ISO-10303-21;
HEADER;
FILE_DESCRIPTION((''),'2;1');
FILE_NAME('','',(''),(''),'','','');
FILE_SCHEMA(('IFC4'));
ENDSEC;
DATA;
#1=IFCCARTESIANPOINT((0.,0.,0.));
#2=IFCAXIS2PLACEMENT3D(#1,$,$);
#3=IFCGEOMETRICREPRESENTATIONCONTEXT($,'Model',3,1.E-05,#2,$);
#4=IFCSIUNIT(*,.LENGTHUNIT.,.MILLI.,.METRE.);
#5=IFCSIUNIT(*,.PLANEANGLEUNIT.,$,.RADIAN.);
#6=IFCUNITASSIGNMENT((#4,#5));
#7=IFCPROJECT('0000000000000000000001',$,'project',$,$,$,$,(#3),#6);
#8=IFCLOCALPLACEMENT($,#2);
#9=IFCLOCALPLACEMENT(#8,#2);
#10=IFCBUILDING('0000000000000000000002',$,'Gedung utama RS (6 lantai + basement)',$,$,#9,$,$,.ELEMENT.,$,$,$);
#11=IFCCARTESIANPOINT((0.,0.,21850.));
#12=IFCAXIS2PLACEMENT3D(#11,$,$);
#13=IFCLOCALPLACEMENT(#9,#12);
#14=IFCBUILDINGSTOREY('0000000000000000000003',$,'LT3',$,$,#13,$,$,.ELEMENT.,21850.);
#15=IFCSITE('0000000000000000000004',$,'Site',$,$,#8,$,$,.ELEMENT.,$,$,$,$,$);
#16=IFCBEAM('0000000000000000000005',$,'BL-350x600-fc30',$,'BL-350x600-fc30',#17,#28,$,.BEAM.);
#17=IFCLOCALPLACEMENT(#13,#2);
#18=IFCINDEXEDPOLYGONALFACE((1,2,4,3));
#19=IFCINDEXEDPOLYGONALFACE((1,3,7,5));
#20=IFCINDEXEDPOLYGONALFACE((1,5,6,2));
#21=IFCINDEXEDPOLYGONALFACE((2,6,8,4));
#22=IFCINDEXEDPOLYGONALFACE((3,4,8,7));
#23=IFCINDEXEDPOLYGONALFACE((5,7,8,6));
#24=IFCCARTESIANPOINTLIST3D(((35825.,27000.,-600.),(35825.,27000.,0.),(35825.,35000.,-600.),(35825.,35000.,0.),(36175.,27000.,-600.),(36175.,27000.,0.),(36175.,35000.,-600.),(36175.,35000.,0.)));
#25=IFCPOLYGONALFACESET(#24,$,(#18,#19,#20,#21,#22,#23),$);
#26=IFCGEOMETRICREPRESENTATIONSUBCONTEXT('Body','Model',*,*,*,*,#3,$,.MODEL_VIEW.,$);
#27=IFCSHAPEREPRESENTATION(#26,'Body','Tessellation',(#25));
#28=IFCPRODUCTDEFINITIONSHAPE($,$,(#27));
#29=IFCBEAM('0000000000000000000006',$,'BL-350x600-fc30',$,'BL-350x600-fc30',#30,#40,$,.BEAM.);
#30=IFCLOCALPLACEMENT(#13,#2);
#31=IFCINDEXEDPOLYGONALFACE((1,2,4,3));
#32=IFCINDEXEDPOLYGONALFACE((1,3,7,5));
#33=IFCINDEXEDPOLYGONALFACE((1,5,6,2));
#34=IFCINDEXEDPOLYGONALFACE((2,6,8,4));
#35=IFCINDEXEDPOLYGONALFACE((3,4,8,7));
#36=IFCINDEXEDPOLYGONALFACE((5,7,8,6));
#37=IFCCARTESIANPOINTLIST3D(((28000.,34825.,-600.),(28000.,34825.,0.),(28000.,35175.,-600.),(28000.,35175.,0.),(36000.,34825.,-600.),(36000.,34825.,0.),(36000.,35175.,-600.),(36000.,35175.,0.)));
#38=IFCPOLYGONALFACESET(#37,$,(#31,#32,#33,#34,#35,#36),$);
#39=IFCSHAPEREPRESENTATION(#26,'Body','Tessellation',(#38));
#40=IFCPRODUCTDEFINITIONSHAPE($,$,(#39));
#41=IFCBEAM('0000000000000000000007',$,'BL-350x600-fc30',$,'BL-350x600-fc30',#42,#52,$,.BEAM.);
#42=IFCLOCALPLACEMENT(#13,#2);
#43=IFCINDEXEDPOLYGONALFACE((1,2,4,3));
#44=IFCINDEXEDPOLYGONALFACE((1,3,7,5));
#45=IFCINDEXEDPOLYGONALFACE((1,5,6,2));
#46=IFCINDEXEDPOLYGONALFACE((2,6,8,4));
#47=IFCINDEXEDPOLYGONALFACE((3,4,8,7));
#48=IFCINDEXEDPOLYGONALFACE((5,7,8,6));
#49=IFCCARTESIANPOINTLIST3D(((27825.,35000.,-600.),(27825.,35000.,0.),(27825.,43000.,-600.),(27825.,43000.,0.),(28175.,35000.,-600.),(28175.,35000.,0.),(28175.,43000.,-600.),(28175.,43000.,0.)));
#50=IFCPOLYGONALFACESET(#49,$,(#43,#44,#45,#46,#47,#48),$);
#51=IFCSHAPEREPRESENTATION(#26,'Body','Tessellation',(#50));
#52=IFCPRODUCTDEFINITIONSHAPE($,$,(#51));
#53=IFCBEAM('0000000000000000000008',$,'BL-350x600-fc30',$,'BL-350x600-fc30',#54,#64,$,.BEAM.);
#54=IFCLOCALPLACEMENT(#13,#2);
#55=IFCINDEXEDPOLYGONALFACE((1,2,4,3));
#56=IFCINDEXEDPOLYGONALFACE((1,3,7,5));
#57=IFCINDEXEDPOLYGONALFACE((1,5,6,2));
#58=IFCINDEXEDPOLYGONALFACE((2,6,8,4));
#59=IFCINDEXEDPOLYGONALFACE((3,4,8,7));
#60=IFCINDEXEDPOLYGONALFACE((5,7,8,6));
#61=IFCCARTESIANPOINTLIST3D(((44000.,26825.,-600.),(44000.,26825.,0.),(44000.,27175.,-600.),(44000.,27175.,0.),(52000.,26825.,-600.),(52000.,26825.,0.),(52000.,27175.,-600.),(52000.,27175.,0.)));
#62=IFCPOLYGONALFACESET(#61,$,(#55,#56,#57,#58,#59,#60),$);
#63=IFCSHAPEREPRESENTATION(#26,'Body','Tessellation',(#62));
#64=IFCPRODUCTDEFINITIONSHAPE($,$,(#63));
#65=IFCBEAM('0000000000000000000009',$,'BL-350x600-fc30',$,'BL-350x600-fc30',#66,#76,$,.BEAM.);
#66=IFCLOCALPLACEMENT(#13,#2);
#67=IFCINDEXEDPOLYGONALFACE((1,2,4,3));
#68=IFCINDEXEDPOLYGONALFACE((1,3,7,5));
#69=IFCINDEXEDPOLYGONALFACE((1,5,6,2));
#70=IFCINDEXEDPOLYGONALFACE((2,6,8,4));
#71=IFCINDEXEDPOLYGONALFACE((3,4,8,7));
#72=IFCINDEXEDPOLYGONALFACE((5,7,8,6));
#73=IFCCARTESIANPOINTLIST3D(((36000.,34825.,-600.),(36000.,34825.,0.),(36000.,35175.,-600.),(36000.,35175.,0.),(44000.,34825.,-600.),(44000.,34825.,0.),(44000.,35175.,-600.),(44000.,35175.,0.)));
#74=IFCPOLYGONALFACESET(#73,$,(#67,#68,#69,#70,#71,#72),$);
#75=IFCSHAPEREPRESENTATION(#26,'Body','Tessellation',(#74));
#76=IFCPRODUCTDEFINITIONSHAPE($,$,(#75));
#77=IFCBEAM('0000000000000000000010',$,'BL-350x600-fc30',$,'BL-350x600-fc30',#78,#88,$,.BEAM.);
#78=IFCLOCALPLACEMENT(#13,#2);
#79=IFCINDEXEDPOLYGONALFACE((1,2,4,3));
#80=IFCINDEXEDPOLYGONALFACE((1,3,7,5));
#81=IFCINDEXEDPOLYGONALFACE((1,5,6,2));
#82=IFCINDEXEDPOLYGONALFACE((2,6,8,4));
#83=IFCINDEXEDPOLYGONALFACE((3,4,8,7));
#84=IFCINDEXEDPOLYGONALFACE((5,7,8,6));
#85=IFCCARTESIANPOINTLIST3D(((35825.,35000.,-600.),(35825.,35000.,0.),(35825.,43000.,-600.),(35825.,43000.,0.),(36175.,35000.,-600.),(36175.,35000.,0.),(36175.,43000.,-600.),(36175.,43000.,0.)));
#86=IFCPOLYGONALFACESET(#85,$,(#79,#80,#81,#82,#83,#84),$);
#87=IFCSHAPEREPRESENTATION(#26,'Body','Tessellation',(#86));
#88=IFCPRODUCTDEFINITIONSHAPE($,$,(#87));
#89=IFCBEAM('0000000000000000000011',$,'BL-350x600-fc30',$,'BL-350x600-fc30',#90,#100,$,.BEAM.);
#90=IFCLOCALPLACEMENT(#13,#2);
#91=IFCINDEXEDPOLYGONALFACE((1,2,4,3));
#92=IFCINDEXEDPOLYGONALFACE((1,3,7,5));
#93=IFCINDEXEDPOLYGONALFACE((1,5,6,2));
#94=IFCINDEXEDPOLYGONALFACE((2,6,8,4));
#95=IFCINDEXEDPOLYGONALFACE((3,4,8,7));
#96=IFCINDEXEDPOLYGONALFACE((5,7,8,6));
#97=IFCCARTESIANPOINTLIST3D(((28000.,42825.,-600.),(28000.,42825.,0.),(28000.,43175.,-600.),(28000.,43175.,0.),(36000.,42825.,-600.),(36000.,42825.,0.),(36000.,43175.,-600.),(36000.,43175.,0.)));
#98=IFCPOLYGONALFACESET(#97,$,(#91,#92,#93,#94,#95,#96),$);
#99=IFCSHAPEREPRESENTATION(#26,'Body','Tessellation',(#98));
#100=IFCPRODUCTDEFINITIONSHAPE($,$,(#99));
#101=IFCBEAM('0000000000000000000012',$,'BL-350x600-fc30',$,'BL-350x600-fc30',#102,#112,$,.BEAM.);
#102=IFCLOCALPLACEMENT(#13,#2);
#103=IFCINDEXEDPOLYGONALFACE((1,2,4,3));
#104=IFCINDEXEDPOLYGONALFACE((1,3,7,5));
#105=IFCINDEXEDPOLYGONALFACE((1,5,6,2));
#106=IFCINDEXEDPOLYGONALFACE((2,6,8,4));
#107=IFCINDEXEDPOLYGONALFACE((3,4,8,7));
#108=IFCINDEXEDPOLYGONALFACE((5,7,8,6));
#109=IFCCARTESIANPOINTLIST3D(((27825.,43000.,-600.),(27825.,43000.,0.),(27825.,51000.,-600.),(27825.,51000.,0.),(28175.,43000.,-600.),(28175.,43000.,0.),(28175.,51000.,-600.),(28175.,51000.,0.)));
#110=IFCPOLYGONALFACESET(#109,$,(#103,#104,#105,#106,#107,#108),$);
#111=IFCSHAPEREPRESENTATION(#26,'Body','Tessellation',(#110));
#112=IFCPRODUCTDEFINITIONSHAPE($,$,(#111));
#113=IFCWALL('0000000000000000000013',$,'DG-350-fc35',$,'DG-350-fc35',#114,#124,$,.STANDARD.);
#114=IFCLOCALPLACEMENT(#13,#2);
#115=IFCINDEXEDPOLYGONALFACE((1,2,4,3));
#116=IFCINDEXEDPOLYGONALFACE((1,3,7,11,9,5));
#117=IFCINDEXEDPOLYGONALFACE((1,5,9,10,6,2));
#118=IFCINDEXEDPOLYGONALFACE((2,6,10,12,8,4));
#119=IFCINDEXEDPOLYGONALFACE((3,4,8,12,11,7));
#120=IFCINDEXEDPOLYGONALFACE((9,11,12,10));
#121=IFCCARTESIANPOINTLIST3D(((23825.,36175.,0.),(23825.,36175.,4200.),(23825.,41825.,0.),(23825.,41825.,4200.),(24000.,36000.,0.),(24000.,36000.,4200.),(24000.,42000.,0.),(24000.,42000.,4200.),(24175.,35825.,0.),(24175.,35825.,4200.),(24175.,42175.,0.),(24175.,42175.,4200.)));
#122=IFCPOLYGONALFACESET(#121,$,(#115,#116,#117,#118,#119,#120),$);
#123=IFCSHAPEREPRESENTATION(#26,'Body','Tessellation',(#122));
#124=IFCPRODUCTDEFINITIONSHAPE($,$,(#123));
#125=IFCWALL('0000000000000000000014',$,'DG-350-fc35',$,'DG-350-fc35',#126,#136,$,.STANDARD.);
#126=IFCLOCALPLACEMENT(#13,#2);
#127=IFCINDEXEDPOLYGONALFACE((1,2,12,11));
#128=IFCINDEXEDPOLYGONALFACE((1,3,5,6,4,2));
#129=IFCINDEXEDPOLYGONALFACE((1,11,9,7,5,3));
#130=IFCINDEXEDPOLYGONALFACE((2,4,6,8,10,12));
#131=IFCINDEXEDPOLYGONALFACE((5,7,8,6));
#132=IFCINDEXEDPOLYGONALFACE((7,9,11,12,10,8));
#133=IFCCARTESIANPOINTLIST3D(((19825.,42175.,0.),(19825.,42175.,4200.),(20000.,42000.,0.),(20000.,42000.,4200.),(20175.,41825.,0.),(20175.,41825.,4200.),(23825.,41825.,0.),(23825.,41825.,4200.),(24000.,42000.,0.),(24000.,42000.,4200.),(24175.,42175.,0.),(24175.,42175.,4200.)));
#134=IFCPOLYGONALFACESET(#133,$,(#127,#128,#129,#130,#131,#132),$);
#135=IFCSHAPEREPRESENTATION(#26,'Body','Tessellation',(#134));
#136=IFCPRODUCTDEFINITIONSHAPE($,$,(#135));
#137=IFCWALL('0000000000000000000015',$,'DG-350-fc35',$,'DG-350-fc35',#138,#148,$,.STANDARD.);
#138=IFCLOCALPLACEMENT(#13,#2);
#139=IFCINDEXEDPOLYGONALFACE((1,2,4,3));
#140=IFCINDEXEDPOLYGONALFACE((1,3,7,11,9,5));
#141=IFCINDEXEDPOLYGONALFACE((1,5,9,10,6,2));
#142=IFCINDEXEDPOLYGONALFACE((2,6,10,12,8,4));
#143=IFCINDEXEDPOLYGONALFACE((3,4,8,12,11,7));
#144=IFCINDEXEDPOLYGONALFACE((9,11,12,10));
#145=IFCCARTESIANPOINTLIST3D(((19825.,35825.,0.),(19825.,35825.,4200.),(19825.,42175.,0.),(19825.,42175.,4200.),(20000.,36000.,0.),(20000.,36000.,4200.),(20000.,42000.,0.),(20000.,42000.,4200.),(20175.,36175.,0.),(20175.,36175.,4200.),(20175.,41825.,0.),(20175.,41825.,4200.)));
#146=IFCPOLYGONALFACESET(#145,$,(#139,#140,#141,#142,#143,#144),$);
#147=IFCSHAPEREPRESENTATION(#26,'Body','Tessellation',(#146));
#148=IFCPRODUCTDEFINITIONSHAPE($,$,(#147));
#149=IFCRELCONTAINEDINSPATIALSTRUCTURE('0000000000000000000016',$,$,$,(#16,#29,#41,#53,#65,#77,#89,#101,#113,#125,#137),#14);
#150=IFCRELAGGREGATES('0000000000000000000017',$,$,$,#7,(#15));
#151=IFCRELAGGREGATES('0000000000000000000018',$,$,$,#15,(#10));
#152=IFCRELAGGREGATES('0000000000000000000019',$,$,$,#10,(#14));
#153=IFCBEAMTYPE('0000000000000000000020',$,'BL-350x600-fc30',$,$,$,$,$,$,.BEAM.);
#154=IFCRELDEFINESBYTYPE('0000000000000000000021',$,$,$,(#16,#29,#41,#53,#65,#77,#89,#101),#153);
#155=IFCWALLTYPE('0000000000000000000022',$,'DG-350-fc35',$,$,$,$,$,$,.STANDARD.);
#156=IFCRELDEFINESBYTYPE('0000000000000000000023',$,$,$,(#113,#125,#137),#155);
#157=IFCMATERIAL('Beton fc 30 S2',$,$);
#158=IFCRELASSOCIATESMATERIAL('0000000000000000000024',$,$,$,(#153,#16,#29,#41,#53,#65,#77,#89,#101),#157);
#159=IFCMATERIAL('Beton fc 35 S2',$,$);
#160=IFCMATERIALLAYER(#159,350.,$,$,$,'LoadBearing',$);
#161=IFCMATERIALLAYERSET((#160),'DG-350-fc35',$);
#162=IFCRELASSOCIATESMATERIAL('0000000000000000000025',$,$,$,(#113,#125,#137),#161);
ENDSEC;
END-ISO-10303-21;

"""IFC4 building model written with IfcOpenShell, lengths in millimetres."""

from ifc_helpers import new_model, si_unit, frame, origin, origin_2d, place, context, subcontext, project, spatial, polyline, rectangle, outline, extrude, material, layer, layer_set, layer_usage, material_profile, profile_set, profile_usage, type_object, element, save


model = new_model("IFC4")

# Units and contexts
model_context = context("Model", 3, precision=1e-05, world=origin())
body_context = subcontext(model_context, "Body", "Model", "MODEL_VIEW")
ifc_project = project(units=[si_unit("LENGTHUNIT", "METRE", prefix="MILLI"), si_unit("PLANEANGLEUNIT", "RADIAN")], contexts=[model_context])

# Site, building, storey
site_placement = place(None, origin())
site = spatial("IfcSite", under=ifc_project, at=site_placement, Name="Site", CompositionType="ELEMENT")
building_placement = place(site_placement, origin())
building = spatial("IfcBuilding", under=site, at=building_placement, Name="Gedung utama RS (6 lantai + basement)", CompositionType="ELEMENT")
storey_placement = place(building_placement, frame((0.0, 0.0, 21850.0)))
storey = spatial("IfcBuildingStorey", under=building, at=storey_placement, Name="LT3", CompositionType="ELEMENT", Elevation=21850.0)

# Beams
ifc_material_1 = material(Name="Beton fc 30 S2")
ifc_material_profile_1 = material_profile(ifc_material_1, rectangle(XDim=350.0, YDim=600.0, at=origin_2d()), Name="BL-350x600-fc30")
ifc_profile_set_1 = profile_set([ifc_material_profile_1], Name="BL-350x600-fc30")
ifc_profile_usage_1 = profile_usage(ifc_profile_set_1, cardinal=8)
beam_type = type_object("IfcBeamType", Name="BL-350x600-fc30", PredefinedType="BEAM", material=ifc_profile_set_1)
beam_1_placement = place(storey_placement, frame((36000.0, 27000.0, -300.0)))
element("IfcBeam", 1, at=beam_1_placement, inside=storey, type_object=beam_type, material=ifc_profile_usage_1, Name="BL-350x600-fc30", ObjectType="BL-350x600-fc30", PredefinedType="BEAM", context=body_context, shape_type="SweptSolid", body=[
    extrude(rectangle(XDim=350.0, YDim=600.0, at=origin_2d()), frame((0.0, 0.0, 0.0), z_axis=(0.0, 1.0, 0.0), x_axis=(-1.0, 0.0, 0.0)), (0.0, 0.0, 1.0), 8000.0),
])
beam_2_placement = place(storey_placement, frame((28000.0, 35000.0, -300.0)))
element("IfcBeam", 2, at=beam_2_placement, inside=storey, type_object=beam_type, material=ifc_profile_usage_1, Name="BL-350x600-fc30", ObjectType="BL-350x600-fc30", PredefinedType="BEAM", context=body_context, shape_type="SweptSolid", body=[
    extrude(rectangle(XDim=350.0, YDim=600.0, at=origin_2d()), frame((0.0, 0.0, 0.0), z_axis=(1.0, 0.0, 0.0), x_axis=(0.0, 1.0, 0.0)), (0.0, 0.0, 1.0), 8000.0),
])
beam_3_placement = place(storey_placement, frame((28000.0, 35000.0, -300.0)))
element("IfcBeam", 3, at=beam_3_placement, inside=storey, type_object=beam_type, material=ifc_profile_usage_1, Name="BL-350x600-fc30", ObjectType="BL-350x600-fc30", PredefinedType="BEAM", context=body_context, shape_type="SweptSolid", body=[
    extrude(rectangle(XDim=350.0, YDim=600.0, at=origin_2d()), frame((0.0, 0.0, 0.0), z_axis=(0.0, 1.0, 0.0), x_axis=(-1.0, 0.0, 0.0)), (0.0, 0.0, 1.0), 8000.0),
])
for number, where, name in (
    (4, (44000.0, 27000.0, -300.0), "BL-350x600-fc30"),
    (5, (36000.0, 35000.0, -300.0), "BL-350x600-fc30"),
):
    element("IfcBeam", number, at=place(storey_placement, frame(where)), inside=storey, type_object=beam_type, material=ifc_profile_usage_1, Name=name, ObjectType="BL-350x600-fc30", PredefinedType="BEAM", context=body_context, shape_type="SweptSolid", body=[
        extrude(rectangle(XDim=350.0, YDim=600.0, at=origin_2d()), frame((0.0, 0.0, 0.0), z_axis=(1.0, 0.0, 0.0), x_axis=(0.0, 1.0, 0.0)), (0.0, 0.0, 1.0), 8000.0),
    ])
beam_4_placement = place(storey_placement, frame((36000.0, 35000.0, -300.0)))
element("IfcBeam", 6, at=beam_4_placement, inside=storey, type_object=beam_type, material=ifc_profile_usage_1, Name="BL-350x600-fc30", ObjectType="BL-350x600-fc30", PredefinedType="BEAM", context=body_context, shape_type="SweptSolid", body=[
    extrude(rectangle(XDim=350.0, YDim=600.0, at=origin_2d()), frame((0.0, 0.0, 0.0), z_axis=(0.0, 1.0, 0.0), x_axis=(-1.0, 0.0, 0.0)), (0.0, 0.0, 1.0), 8000.0),
])
beam_5_placement = place(storey_placement, frame((28000.0, 43000.0, -300.0)))
element("IfcBeam", 7, at=beam_5_placement, inside=storey, type_object=beam_type, material=ifc_profile_usage_1, Name="BL-350x600-fc30", ObjectType="BL-350x600-fc30", PredefinedType="BEAM", context=body_context, shape_type="SweptSolid", body=[
    extrude(rectangle(XDim=350.0, YDim=600.0, at=origin_2d()), frame((0.0, 0.0, 0.0), z_axis=(1.0, 0.0, 0.0), x_axis=(0.0, 1.0, 0.0)), (0.0, 0.0, 1.0), 8000.0),
])
beam_6_placement = place(storey_placement, frame((28000.0, 43000.0, -300.0)))
element("IfcBeam", 8, at=beam_6_placement, inside=storey, type_object=beam_type, material=ifc_profile_usage_1, Name="BL-350x600-fc30", ObjectType="BL-350x600-fc30", PredefinedType="BEAM", context=body_context, shape_type="SweptSolid", body=[
    extrude(rectangle(XDim=350.0, YDim=600.0, at=origin_2d()), frame((0.0, 0.0, 0.0), z_axis=(0.0, 1.0, 0.0), x_axis=(-1.0, 0.0, 0.0)), (0.0, 0.0, 1.0), 8000.0),
])

# Walls
ifc_material_2 = material(Name="Beton fc 35 S2")
ifc_layer = layer(ifc_material_2, 350.0, Category="LoadBearing")
ifc_layer_set = layer_set([ifc_layer], Name="DG-350-fc35")
ifc_layer_usage = layer_usage(ifc_layer_set, "AXIS2", "NEGATIVE", 175.0)
wall_type = type_object("IfcWallType", Name="DG-350-fc35", PredefinedType="STANDARD")
wall_1_placement = place(storey_placement, frame((24000.0, 36000.0, 0.0), z_axis=(0.0, 0.0, 1.0), x_axis=(0.0, 1.0, 0.0)))
element("IfcWall", 9, at=wall_1_placement, inside=storey, type_object=wall_type, material=ifc_layer_usage, Name="DG-350-fc35", ObjectType="DG-350-fc35", PredefinedType="STANDARD", context=body_context, shape_type="SweptSolid", body=[
    extrude(outline(polyline([(-175.0, -175.0), (0.0, 0.0), (175.0, 175.0), (5825.0, 175.0), (6000.0, 0.0), (6175.0, -175.0), (-175.0, -175.0)])), origin(), (0.0, 0.0, 1.0), 4200.0),
])
wall_2_placement = place(storey_placement, frame((24000.0, 42000.0, 0.0), z_axis=(0.0, 0.0, 1.0), x_axis=(-1.0, 0.0, 0.0)))
element("IfcWall", 10, at=wall_2_placement, inside=storey, type_object=wall_type, material=ifc_layer_usage, Name="DG-350-fc35", ObjectType="DG-350-fc35", PredefinedType="STANDARD", context=body_context, shape_type="SweptSolid", body=[
    extrude(outline(polyline([(-175.0, -175.0), (0.0, 0.0), (175.0, 175.0), (3825.0, 175.0), (4000.0, 0.0), (4175.0, -175.0), (-175.0, -175.0)])), origin(), (0.0, 0.0, 1.0), 4200.0),
])
wall_3_placement = place(storey_placement, frame((20000.0, 42000.0, 0.0), z_axis=(0.0, 0.0, 1.0), x_axis=(0.0, -1.0, 0.0)))
element("IfcWall", 11, at=wall_3_placement, inside=storey, type_object=wall_type, material=ifc_layer_usage, Name="DG-350-fc35", ObjectType="DG-350-fc35", PredefinedType="STANDARD", context=body_context, shape_type="SweptSolid", body=[
    extrude(outline(polyline([(-175.0, -175.0), (0.0, 0.0), (175.0, 175.0), (5825.0, 175.0), (6000.0, 0.0), (6175.0, -175.0), (-175.0, -175.0)])), origin(), (0.0, 0.0, 1.0), 4200.0),
])

save(model, "model.ifc")
